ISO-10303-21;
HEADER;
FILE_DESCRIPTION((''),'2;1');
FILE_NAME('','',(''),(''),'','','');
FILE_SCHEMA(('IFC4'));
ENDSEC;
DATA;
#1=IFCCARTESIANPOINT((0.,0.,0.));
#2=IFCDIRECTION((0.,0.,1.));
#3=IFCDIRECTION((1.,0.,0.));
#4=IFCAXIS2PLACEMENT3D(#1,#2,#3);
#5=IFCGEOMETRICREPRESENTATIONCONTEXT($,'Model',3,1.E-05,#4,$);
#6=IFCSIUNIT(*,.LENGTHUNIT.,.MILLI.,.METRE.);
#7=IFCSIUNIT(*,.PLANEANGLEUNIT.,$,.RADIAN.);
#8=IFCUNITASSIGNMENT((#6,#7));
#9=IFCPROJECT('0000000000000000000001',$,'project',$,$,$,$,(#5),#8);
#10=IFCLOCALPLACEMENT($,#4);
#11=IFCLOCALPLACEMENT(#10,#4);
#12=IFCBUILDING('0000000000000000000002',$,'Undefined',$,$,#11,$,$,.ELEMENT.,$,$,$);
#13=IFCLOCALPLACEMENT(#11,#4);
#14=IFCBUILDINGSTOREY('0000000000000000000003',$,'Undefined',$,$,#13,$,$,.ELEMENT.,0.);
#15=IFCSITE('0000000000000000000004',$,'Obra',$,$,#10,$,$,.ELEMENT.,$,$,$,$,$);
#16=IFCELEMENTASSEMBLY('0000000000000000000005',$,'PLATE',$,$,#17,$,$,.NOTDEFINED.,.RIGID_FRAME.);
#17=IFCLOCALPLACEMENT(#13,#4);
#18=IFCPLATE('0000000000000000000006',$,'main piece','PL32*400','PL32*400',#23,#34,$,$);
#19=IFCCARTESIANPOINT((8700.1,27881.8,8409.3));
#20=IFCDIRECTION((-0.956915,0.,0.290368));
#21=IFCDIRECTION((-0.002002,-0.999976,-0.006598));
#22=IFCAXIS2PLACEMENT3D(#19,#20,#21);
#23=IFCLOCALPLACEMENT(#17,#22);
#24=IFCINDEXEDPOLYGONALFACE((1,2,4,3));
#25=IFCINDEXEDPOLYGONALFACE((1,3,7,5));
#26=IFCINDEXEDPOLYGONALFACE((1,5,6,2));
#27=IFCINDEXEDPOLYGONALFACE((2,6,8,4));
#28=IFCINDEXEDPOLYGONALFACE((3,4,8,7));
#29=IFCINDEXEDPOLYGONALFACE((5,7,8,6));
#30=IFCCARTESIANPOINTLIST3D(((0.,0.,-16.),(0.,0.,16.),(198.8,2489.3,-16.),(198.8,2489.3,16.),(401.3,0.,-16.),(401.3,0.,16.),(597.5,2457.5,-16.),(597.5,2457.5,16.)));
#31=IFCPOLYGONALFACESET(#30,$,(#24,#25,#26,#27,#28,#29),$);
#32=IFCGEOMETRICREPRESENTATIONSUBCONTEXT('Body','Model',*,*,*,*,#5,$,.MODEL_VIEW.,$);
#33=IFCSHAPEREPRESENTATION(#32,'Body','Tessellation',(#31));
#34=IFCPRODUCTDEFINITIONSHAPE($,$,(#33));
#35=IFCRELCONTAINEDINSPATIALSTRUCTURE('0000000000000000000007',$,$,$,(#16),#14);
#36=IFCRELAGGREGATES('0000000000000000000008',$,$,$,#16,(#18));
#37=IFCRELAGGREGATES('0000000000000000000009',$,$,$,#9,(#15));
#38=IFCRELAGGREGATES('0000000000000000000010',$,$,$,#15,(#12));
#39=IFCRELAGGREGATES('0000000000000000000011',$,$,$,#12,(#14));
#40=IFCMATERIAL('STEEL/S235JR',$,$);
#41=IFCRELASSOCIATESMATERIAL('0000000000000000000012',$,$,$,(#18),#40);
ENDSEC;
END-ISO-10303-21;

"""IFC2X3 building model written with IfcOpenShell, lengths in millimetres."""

from ifc_helpers import new_model, si_unit, frame, origin_with_axes, place, context, subcontext, project, spatial, polyline, outline, extrude, material, element, aggregate, save


model = new_model("IFC2X3")

# Units and contexts
model_context = context("Model", 3, precision=1e-05, world=origin_with_axes())
body_context = subcontext(model_context, "Body", "Model", "MODEL_VIEW")
ifc_project = project(units=[si_unit("LENGTHUNIT", "METRE", prefix="MILLI"), si_unit("PLANEANGLEUNIT", "RADIAN")], contexts=[model_context])

# Site, building, storey
site_placement = place(None, origin_with_axes())
site = spatial("IfcSite", under=ifc_project, at=site_placement, Name="Obra", CompositionType="ELEMENT")
building_placement = place(site_placement, origin_with_axes())
building = spatial("IfcBuilding", under=site, at=building_placement, Name="Undefined", CompositionType="ELEMENT")
storey_placement = place(building_placement, origin_with_axes())
storey = spatial("IfcBuildingStorey", under=building, at=storey_placement, Name="Undefined", CompositionType="ELEMENT", Elevation=0.0)

# Shared definitions
ifc_material_1 = material(Name="STEEL/S235JR")

# Element assembly, plate
assembly_1_placement = place(storey_placement, origin_with_axes())
assembly_1 = element("IfcElementAssembly", 1, at=assembly_1_placement, inside=storey, Name="PLATE", AssemblyPlace="NOTDEFINED", PredefinedType="RIGID_FRAME")
plate_1_placement = place(assembly_1_placement, frame((8700.1, 27881.8, 8409.3), z_axis=(-0.956915, 0.0, 0.290368), x_axis=(-0.002002, -0.999976, -0.006598)))
plate_1 = element("IfcPlate", 2, at=plate_1_placement, material=ifc_material_1, Name="main piece", Description="PL32*400", ObjectType="PL32*400", context=body_context, shape_type="SweptSolid", body=[
    extrude(outline(polyline([(0.0, 0.0), (401.3, 0.0), (597.5, 2457.5), (198.8, 2489.3), (0.0, 0.0)])), frame((0.0, 0.0, -16.0), z_axis=(0.0, 0.0, 1.0), x_axis=(1.0, 0.0, 0.0)), (0.0, 0.0, 1.0), 32.0),
])
aggregate(assembly_1, [plate_1])

save(model, "model.ifc")
